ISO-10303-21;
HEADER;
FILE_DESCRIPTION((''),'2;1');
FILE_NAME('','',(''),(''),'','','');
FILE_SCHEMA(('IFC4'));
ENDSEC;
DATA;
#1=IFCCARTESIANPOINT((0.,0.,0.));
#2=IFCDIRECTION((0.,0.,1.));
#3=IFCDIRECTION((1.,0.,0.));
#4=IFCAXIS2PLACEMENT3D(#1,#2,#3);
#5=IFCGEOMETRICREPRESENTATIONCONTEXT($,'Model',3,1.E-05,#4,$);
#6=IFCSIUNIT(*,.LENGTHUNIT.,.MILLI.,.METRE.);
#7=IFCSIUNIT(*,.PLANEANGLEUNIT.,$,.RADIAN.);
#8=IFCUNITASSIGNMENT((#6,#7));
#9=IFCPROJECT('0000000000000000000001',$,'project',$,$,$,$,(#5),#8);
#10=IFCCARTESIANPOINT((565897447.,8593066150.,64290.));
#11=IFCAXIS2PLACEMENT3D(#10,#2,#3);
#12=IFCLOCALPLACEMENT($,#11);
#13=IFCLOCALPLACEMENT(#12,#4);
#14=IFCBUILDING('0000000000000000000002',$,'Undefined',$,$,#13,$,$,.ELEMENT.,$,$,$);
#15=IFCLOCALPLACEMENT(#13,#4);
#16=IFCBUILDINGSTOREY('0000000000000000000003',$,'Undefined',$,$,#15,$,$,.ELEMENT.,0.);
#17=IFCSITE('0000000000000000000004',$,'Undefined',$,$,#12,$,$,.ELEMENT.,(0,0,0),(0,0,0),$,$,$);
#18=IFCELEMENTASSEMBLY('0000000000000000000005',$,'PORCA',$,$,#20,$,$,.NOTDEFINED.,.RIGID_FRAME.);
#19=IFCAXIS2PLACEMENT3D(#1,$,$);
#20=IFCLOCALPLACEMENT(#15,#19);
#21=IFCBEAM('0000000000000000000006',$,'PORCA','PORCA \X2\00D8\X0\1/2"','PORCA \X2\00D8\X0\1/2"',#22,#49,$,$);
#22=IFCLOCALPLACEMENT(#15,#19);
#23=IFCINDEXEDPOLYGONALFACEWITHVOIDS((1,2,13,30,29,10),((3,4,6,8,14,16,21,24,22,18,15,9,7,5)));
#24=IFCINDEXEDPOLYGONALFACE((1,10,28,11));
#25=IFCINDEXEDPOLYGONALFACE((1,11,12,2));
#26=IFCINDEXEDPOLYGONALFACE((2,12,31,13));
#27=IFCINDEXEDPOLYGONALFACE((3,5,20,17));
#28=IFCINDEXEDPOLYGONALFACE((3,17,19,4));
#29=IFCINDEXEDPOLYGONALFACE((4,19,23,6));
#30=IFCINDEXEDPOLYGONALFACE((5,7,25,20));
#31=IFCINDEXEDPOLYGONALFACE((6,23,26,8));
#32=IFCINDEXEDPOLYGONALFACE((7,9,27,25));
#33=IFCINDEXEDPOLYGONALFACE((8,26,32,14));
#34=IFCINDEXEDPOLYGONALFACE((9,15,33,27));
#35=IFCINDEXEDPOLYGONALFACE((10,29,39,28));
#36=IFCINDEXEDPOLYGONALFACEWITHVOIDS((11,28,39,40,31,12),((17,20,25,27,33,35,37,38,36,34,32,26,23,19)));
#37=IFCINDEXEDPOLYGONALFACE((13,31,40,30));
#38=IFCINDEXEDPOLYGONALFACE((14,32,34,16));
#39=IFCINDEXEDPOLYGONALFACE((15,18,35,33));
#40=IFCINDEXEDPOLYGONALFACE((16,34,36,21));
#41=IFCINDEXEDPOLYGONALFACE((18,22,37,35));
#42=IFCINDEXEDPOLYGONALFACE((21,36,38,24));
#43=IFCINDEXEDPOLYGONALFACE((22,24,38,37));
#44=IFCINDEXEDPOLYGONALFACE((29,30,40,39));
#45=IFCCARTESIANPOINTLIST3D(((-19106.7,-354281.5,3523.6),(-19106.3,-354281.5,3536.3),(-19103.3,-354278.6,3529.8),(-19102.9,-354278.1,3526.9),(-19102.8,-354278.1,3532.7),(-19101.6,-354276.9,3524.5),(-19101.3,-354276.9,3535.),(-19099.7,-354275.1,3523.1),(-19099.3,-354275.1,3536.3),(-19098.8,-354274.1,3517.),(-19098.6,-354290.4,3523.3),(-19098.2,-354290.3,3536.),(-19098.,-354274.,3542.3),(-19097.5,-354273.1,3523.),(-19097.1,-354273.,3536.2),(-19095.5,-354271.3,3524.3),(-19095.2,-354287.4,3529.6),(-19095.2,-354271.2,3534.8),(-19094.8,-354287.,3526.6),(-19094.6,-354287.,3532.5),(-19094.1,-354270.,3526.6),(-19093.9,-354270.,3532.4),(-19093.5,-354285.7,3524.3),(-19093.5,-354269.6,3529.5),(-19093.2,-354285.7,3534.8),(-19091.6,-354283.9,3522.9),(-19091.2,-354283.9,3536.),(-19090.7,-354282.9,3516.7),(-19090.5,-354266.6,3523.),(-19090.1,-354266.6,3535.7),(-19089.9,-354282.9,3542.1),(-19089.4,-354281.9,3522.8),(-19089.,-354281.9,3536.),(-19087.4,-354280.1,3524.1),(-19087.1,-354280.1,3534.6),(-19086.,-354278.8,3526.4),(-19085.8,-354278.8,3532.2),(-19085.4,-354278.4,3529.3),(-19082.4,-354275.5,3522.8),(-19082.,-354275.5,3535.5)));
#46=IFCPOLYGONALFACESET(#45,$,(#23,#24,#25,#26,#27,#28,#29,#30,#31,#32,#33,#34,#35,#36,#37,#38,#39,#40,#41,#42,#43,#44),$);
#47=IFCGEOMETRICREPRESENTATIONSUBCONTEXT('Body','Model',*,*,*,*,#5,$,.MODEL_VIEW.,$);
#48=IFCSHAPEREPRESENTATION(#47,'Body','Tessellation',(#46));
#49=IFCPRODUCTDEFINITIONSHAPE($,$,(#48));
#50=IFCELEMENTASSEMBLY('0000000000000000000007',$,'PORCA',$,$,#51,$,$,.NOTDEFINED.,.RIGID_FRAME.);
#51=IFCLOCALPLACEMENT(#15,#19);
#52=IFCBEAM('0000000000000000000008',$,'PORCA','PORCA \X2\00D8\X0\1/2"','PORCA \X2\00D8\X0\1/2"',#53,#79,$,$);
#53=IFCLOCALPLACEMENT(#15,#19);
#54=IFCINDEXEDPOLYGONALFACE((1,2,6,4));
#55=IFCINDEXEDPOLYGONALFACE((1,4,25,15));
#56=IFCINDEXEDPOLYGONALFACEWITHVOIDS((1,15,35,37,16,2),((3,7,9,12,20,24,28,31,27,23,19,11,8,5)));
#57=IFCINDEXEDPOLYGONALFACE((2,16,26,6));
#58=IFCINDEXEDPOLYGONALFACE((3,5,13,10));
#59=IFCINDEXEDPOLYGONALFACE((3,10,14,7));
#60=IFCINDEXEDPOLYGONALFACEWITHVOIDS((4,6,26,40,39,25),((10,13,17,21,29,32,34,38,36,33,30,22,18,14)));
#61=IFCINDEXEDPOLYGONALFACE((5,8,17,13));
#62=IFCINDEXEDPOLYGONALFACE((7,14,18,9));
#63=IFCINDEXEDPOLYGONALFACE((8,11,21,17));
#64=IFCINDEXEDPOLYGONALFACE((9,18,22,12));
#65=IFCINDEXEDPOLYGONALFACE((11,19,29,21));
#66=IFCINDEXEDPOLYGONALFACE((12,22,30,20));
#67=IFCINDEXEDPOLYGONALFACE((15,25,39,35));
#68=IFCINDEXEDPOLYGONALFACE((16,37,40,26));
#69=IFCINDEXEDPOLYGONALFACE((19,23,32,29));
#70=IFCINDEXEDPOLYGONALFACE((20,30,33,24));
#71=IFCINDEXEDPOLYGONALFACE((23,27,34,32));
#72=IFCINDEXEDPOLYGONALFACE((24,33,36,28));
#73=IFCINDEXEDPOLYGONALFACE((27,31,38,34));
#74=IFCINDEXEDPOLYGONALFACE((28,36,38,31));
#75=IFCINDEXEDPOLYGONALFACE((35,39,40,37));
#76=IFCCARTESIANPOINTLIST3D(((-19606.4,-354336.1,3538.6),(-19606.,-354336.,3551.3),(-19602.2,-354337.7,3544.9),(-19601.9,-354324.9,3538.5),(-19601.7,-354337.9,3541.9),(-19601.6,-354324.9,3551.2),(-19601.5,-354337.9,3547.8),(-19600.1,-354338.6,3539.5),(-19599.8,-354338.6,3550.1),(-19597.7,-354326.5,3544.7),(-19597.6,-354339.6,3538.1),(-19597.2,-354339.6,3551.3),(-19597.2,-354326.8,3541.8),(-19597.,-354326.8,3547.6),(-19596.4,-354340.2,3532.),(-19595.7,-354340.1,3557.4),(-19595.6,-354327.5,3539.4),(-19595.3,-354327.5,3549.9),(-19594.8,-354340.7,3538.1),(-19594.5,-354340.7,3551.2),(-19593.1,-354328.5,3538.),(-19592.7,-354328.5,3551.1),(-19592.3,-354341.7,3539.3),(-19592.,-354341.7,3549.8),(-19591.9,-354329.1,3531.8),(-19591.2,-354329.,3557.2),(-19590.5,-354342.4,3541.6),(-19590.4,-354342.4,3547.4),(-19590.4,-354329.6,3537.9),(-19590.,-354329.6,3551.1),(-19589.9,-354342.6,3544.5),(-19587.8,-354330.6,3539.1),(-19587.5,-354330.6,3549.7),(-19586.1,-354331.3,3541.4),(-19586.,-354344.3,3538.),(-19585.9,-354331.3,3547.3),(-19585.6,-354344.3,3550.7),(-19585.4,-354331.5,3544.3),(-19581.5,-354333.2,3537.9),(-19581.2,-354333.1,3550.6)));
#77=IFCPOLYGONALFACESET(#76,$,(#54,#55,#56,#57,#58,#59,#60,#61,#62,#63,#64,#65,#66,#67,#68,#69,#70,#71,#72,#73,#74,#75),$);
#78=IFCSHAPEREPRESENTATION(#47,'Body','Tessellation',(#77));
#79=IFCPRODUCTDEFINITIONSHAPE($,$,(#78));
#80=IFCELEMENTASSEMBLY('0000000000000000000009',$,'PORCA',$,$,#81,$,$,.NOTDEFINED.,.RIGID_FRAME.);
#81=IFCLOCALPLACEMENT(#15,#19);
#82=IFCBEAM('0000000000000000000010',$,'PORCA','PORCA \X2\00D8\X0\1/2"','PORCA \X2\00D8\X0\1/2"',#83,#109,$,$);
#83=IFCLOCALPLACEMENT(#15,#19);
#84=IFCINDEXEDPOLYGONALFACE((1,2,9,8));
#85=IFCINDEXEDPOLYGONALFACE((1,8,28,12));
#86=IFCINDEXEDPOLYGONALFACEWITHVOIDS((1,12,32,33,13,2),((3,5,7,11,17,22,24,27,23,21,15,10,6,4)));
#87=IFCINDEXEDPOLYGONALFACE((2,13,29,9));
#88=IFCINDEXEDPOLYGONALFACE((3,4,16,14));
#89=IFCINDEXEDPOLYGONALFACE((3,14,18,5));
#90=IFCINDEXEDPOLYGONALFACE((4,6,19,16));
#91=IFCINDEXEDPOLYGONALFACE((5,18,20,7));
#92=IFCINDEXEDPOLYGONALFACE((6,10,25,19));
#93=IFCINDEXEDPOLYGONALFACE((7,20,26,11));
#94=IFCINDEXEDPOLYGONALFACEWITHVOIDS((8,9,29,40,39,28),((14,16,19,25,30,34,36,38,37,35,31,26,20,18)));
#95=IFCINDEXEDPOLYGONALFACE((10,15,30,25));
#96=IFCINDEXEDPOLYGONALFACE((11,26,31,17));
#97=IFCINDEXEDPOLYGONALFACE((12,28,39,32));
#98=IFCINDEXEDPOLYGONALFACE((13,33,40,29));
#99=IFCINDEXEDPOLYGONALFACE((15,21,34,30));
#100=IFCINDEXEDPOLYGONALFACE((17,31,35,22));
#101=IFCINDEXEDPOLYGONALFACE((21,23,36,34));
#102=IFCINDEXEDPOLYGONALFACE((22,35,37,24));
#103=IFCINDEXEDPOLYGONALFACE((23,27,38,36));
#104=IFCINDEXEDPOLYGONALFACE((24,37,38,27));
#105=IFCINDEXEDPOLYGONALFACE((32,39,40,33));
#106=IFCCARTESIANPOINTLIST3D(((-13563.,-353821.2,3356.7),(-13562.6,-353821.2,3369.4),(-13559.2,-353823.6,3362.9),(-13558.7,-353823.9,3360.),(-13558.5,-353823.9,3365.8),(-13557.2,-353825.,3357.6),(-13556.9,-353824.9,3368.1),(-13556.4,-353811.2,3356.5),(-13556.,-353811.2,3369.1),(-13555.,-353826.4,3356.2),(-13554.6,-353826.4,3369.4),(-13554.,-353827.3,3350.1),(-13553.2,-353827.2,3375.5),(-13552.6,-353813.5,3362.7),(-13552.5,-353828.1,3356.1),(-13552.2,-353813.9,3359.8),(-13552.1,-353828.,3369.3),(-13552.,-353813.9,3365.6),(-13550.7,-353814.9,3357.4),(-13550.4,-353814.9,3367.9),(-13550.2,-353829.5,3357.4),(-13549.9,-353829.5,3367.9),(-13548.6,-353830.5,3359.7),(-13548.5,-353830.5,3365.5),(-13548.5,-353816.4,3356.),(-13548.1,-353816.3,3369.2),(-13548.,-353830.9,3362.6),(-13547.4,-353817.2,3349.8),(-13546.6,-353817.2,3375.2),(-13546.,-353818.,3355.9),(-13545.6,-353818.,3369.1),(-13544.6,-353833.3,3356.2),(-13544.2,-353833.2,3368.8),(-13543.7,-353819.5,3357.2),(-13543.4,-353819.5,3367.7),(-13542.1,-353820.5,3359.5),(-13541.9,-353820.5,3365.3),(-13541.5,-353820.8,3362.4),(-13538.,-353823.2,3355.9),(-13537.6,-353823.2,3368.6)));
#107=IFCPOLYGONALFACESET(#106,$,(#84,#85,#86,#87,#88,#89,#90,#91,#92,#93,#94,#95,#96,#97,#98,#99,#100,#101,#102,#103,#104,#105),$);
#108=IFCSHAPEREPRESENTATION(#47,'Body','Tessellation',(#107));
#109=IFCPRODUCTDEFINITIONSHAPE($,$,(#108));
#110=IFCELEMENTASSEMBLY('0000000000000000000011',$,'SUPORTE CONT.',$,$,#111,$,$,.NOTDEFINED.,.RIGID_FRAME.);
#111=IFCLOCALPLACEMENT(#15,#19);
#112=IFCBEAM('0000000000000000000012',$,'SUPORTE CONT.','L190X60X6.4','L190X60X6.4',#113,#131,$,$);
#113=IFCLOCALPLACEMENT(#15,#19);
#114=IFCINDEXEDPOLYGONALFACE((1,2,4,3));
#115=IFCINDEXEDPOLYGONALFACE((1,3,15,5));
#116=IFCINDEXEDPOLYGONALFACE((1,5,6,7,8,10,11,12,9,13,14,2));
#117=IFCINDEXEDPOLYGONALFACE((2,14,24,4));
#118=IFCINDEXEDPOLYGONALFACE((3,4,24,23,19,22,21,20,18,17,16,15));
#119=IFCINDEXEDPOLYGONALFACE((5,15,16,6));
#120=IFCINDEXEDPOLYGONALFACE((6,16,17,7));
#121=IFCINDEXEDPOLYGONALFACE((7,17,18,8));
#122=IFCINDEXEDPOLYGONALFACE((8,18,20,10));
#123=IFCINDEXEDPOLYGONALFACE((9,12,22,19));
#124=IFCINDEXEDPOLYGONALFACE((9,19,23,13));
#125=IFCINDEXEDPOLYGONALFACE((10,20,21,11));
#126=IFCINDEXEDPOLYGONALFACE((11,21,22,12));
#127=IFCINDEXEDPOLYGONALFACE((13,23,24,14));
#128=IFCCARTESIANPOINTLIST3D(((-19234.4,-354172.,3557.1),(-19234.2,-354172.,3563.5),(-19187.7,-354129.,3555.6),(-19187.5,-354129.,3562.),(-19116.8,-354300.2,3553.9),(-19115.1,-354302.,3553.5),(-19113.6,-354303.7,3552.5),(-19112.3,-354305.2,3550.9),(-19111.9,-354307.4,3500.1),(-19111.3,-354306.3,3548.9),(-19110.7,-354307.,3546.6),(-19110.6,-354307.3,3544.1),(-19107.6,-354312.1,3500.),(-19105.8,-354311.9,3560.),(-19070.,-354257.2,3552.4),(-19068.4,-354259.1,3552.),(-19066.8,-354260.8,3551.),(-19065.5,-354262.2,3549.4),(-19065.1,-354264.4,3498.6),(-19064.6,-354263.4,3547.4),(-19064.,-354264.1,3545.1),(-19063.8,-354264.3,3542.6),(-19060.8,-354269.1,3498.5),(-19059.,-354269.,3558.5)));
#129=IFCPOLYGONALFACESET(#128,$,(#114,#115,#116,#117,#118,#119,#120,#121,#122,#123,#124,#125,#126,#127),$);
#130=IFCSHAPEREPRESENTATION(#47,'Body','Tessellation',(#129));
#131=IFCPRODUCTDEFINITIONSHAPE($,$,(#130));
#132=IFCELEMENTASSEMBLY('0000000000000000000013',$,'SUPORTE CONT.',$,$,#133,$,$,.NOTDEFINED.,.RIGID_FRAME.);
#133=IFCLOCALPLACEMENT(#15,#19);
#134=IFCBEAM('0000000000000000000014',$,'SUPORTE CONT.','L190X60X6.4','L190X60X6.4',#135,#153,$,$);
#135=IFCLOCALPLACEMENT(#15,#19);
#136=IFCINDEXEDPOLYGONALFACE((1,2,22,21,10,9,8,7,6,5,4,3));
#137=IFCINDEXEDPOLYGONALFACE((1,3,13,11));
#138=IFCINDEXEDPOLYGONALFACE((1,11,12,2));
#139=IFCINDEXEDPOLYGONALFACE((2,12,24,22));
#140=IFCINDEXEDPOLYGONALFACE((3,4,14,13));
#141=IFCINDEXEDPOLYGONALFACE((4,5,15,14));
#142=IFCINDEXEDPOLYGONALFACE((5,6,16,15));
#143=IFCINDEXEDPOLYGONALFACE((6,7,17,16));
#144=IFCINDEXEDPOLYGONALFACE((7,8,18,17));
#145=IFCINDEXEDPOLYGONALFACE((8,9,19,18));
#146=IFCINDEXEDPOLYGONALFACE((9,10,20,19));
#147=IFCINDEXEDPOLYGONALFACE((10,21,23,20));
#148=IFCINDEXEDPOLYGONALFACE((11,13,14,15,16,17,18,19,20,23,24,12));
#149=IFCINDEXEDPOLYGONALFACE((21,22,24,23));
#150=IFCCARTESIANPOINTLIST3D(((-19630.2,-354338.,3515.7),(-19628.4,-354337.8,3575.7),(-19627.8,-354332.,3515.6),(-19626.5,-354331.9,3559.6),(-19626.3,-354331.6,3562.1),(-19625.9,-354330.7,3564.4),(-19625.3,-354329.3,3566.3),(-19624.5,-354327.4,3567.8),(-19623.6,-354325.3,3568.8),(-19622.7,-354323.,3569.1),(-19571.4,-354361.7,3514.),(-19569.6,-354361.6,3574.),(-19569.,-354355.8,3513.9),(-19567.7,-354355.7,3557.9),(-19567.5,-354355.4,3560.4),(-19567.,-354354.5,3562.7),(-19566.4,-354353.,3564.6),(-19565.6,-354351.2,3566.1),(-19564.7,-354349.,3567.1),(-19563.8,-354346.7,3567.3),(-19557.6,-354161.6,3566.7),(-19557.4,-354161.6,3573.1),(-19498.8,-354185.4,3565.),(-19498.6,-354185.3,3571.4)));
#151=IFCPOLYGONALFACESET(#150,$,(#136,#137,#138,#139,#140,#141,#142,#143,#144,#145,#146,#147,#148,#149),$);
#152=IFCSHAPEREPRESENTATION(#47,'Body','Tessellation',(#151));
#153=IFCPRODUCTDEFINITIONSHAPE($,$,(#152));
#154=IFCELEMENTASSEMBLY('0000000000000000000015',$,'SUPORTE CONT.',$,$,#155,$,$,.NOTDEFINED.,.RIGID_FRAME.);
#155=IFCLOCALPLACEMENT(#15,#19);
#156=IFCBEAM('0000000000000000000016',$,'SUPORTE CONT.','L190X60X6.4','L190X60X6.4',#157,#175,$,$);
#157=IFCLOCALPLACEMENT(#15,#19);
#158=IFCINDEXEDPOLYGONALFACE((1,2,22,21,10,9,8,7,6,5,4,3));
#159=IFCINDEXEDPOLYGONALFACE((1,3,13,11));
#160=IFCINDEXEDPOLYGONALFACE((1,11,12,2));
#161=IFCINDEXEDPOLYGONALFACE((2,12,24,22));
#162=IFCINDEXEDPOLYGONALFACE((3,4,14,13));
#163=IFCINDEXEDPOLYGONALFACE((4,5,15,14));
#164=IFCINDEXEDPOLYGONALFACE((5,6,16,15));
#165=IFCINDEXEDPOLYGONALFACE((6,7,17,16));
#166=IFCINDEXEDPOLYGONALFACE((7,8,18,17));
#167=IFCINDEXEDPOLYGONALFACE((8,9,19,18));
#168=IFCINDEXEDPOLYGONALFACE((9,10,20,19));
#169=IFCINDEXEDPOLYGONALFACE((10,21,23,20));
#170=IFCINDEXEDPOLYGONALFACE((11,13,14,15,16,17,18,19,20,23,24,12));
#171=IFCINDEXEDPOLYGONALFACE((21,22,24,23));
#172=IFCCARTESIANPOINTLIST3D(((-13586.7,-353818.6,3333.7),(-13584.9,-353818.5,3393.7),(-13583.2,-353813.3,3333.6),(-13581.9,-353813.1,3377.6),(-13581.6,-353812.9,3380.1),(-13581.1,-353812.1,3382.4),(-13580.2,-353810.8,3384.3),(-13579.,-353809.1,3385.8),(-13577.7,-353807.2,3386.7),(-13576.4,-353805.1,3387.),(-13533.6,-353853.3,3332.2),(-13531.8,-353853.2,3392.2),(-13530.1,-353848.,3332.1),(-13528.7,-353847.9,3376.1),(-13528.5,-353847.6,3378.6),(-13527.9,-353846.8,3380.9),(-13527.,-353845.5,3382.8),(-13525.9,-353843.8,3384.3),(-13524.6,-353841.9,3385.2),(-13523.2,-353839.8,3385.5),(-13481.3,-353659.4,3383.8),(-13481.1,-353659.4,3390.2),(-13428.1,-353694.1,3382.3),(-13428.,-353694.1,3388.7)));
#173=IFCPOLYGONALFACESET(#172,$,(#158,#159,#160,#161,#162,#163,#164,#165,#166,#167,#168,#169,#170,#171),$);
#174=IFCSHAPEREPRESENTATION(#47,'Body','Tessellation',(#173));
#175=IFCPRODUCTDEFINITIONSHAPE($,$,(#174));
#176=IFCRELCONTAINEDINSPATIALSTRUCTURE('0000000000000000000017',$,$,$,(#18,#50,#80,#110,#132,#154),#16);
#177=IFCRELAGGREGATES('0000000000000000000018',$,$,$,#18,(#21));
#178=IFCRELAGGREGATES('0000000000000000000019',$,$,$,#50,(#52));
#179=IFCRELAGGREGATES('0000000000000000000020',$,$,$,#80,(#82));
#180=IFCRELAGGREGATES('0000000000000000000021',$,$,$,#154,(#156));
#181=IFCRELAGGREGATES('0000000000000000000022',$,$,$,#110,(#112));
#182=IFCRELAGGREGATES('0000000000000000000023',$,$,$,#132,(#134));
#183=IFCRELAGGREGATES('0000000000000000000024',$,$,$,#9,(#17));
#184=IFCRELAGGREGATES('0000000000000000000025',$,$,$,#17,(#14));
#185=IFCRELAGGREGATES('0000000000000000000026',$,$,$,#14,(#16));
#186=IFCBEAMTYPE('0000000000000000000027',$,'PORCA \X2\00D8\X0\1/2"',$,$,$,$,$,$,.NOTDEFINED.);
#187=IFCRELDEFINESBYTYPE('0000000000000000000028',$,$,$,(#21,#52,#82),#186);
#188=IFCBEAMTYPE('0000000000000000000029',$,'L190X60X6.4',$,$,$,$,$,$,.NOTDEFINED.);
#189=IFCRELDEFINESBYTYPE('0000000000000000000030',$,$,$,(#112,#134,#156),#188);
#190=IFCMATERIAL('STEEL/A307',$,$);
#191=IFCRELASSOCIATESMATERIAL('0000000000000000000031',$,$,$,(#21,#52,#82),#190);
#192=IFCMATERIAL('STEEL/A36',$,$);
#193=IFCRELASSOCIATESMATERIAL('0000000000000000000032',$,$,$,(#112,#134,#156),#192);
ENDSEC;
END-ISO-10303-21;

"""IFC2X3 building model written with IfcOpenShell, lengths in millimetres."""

from ifc_helpers import new_model, si_unit, frame, origin_with_axes, origin_2d_with_axis, place, context, subcontext, project, spatial, polyline, l_section, outline, extrude, material, type_object, element, aggregate, save


model = new_model("IFC2X3")

# Units and contexts
model_context = context("Model", 3, precision=1e-05, world=origin_with_axes())
body_context = subcontext(model_context, "Body", "Model", "MODEL_VIEW")
ifc_project = project(units=[si_unit("LENGTHUNIT", "METRE", prefix="MILLI"), si_unit("PLANEANGLEUNIT", "RADIAN")], contexts=[model_context])

# Site, building, storey
site_placement = place(None, frame((565897447.0, 8593066150.0, 64290.0), z_axis=(0.0, 0.0, 1.0), x_axis=(1.0, 0.0, 0.0)))
site = spatial("IfcSite", under=ifc_project, at=site_placement, Name="Undefined", CompositionType="ELEMENT", RefLatitude=(0, 0, 0), RefLongitude=(0, 0, 0))
building_placement = place(site_placement, origin_with_axes())
building = spatial("IfcBuilding", under=site, at=building_placement, Name="Undefined", CompositionType="ELEMENT")
storey_placement = place(building_placement, origin_with_axes())
storey = spatial("IfcBuildingStorey", under=building, at=storey_placement, Name="Undefined", CompositionType="ELEMENT", Elevation=0.0)

# Element assemblies, beams
ifc_material_1 = material(Name="STEEL/A36")
ifc_material_2 = material(Name="STEEL/A307")
assembly_1_placement = place(storey_placement, origin_with_axes())
assembly_1 = element("IfcElementAssembly", 1, at=assembly_1_placement, inside=storey, Name="PORCA", AssemblyPlace="NOTDEFINED", PredefinedType="RIGID_FRAME")
beam_type_1 = type_object("IfcBeamType", Name="PORCA Ø1/2\"", PredefinedType="NOTDEFINED")
beam_1_placement = place(assembly_1_placement, frame((-19098.4, -354274.1, 3529.6), z_axis=(-0.736334, -0.676203, 0.02368), x_axis=(0.675958, -0.736711, -0.018398)))
beam_1 = element("IfcBeam", 2, at=beam_1_placement, type_object=beam_type_1, material=ifc_material_2, Name="PORCA", Description="PORCA Ø1/2\"", ObjectType="PORCA Ø1/2\"", context=body_context, shape_type="SweptSolid", body=[
    extrude(outline(polyline([(-12.7, 0.0), (-6.3, 11.0), (6.3, 11.0), (12.7, 0.0), (6.3, -11.0), (-6.3, -11.0), (-12.7, 0.0)]), holes=[polyline([(5.3, 4.2), (2.9, 6.0), (0.0, 6.7), (-2.9, 6.0), (-5.3, 4.2), (-6.6, 1.5), (-6.6, -1.5), (-5.3, -4.2), (-2.9, -6.0), (0.0, -6.7), (2.9, -6.0), (5.3, -4.2), (6.6, -1.5), (6.6, 1.5), (5.3, 4.2)])]), frame((12.0, 0.0, 0.0), z_axis=(-1.0, 0.0, 0.0), x_axis=(0.0, -1.0, 0.0)), (0.0, 0.0, 1.0), 12.0),
])
aggregate(assembly_1, [beam_1])
assembly_2_placement = place(storey_placement, origin_with_axes())
assembly_2 = element("IfcElementAssembly", 3, at=assembly_2_placement, inside=storey, Name="PORCA", AssemblyPlace="NOTDEFINED", PredefinedType="RIGID_FRAME")
beam_2_placement = place(assembly_2_placement, frame((-19591.5, -354329.0, 3544.5), z_axis=(-0.92709, 0.373879, 0.026799), x_axis=(-0.373645, -0.927474, 0.013454)))
beam_2 = element("IfcBeam", 4, at=beam_2_placement, type_object=beam_type_1, material=ifc_material_2, Name="PORCA", Description="PORCA Ø1/2\"", ObjectType="PORCA Ø1/2\"", context=body_context, shape_type="SweptSolid", body=[
    extrude(outline(polyline([(-12.7, 0.0), (-6.3, 11.0), (6.3, 11.0), (12.7, 0.0), (6.3, -11.0), (-6.3, -11.0), (-12.7, 0.0)]), holes=[polyline([(5.3, 4.2), (2.9, 6.0), (0.0, 6.7), (-2.9, 6.0), (-5.3, 4.2), (-6.6, 1.5), (-6.6, -1.5), (-5.3, -4.2), (-2.9, -6.0), (0.0, -6.7), (2.9, -6.0), (5.3, -4.2), (6.6, -1.5), (6.6, 1.5), (5.3, 4.2)])]), frame((12.0, 0.0, 0.0), z_axis=(-1.0, 0.0, 0.0), x_axis=(0.0, -1.0, 0.0)), (0.0, 0.0, 1.0), 12.0),
])
aggregate(assembly_2, [beam_2])
assembly_3_placement = place(storey_placement, origin_with_axes())
assembly_3 = element("IfcElementAssembly", 5, at=assembly_3_placement, inside=storey, Name="PORCA", AssemblyPlace="NOTDEFINED", PredefinedType="RIGID_FRAME")
beam_3_placement = place(assembly_3_placement, frame((-13547.0, -353817.2, 3362.5), z_axis=(-0.836984, 0.546715, 0.02368), x_axis=(-0.546411, -0.837315, 0.018398)))
beam_3 = element("IfcBeam", 6, at=beam_3_placement, type_object=beam_type_1, material=ifc_material_2, Name="PORCA", Description="PORCA Ø1/2\"", ObjectType="PORCA Ø1/2\"", context=body_context, shape_type="SweptSolid", body=[
    extrude(outline(polyline([(-12.7, 0.0), (-6.3, 11.0), (6.3, 11.0), (12.7, 0.0), (6.3, -11.0), (-6.3, -11.0), (-12.7, 0.0)]), holes=[polyline([(5.3, 4.2), (2.9, 6.0), (0.0, 6.7), (-2.9, 6.0), (-5.3, 4.2), (-6.6, 1.5), (-6.6, -1.5), (-5.3, -4.2), (-2.9, -6.0), (0.0, -6.7), (2.9, -6.0), (5.3, -4.2), (6.6, -1.5), (6.6, 1.5), (5.3, 4.2)])]), frame((12.0, 0.0, 0.0), z_axis=(-1.0, 0.0, 0.0), x_axis=(0.0, -1.0, 0.0)), (0.0, 0.0, 1.0), 12.0),
])
aggregate(assembly_3, [beam_3])
assembly_4_placement = place(storey_placement, origin_with_axes())
assembly_4 = element("IfcElementAssembly", 7, at=assembly_4_placement, inside=storey, Name="SUPORTE CONT.", AssemblyPlace="NOTDEFINED", PredefinedType="RIGID_FRAME")
beam_type_2 = type_object("IfcBeamType", Name="L190X60X6.4", PredefinedType="NOTDEFINED")
beam_4_placement = place(assembly_4_placement, frame((-19124.1, -354199.1, 3530.2), z_axis=(-0.675958, 0.736711, 0.018398), x_axis=(-0.736334, -0.676203, 0.02368)))
beam_4 = element("IfcBeam", 8, at=beam_4_placement, type_object=beam_type_2, material=ifc_material_1, Name="SUPORTE CONT.", Description="L190X60X6.4", ObjectType="L190X60X6.4", context=body_context, shape_type="SweptSolid", body=[
    extrude(l_section(Depth=190.0, Width=60.0, Thickness=6.4, FilletRadius=9.6, at=origin_2d_with_axis()), frame((63.5, 0.0, 0.0), z_axis=(-1.0, 0.0, 0.0), x_axis=(0.0, -1.0, 0.0)), (0.0, 0.0, 1.0), 63.5),
])
assembly_5_placement = place(storey_placement, origin_with_axes())
assembly_5 = element("IfcElementAssembly", 9, at=assembly_5_placement, inside=storey, Name="SUPORTE CONT.", AssemblyPlace="NOTDEFINED", PredefinedType="RIGID_FRAME")
beam_5_placement = place(assembly_5_placement, frame((-19535.0, -354273.5, 3542.7), z_axis=(0.373645, 0.927474, -0.013454), x_axis=(-0.92709, 0.373879, 0.026799)))
beam_5 = element("IfcBeam", 10, at=beam_5_placement, type_object=beam_type_2, material=ifc_material_1, Name="SUPORTE CONT.", Description="L190X60X6.4", ObjectType="L190X60X6.4", context=body_context, shape_type="SweptSolid", body=[
    extrude(l_section(Depth=190.0, Width=60.0, Thickness=6.4, FilletRadius=9.6, at=origin_2d_with_axis()), frame((63.5, 0.0, 0.0), z_axis=(-1.0, 0.0, 0.0), x_axis=(0.0, -1.0, 0.0)), (0.0, 0.0, 1.0), 63.5),
])

# Element assembly, beam
assembly_6_placement = place(storey_placement, origin_with_axes())
assembly_6 = element("IfcElementAssembly", 11, at=assembly_6_placement, inside=storey, Name="SUPORTE CONT.", AssemblyPlace="NOTDEFINED", PredefinedType="RIGID_FRAME")
beam_6_placement = place(assembly_6_placement, frame((-13480.8, -353773.7, 3360.5), z_axis=(0.546411, 0.837315, -0.018398), x_axis=(-0.836984, 0.546715, 0.02368)))
beam_6 = element("IfcBeam", 12, at=beam_6_placement, type_object=beam_type_2, material=ifc_material_1, Name="SUPORTE CONT.", Description="L190X60X6.4", ObjectType="L190X60X6.4", context=body_context, shape_type="SweptSolid", body=[
    extrude(l_section(Depth=190.0, Width=60.0, Thickness=6.4, FilletRadius=9.6, at=origin_2d_with_axis()), frame((63.5, 0.0, 0.0), z_axis=(-1.0, 0.0, 0.0), x_axis=(0.0, -1.0, 0.0)), (0.0, 0.0, 1.0), 63.5),
])
aggregate(assembly_6, [beam_6])

aggregate(assembly_4, [beam_4])
aggregate(assembly_5, [beam_5])

save(model, "model.ifc")
